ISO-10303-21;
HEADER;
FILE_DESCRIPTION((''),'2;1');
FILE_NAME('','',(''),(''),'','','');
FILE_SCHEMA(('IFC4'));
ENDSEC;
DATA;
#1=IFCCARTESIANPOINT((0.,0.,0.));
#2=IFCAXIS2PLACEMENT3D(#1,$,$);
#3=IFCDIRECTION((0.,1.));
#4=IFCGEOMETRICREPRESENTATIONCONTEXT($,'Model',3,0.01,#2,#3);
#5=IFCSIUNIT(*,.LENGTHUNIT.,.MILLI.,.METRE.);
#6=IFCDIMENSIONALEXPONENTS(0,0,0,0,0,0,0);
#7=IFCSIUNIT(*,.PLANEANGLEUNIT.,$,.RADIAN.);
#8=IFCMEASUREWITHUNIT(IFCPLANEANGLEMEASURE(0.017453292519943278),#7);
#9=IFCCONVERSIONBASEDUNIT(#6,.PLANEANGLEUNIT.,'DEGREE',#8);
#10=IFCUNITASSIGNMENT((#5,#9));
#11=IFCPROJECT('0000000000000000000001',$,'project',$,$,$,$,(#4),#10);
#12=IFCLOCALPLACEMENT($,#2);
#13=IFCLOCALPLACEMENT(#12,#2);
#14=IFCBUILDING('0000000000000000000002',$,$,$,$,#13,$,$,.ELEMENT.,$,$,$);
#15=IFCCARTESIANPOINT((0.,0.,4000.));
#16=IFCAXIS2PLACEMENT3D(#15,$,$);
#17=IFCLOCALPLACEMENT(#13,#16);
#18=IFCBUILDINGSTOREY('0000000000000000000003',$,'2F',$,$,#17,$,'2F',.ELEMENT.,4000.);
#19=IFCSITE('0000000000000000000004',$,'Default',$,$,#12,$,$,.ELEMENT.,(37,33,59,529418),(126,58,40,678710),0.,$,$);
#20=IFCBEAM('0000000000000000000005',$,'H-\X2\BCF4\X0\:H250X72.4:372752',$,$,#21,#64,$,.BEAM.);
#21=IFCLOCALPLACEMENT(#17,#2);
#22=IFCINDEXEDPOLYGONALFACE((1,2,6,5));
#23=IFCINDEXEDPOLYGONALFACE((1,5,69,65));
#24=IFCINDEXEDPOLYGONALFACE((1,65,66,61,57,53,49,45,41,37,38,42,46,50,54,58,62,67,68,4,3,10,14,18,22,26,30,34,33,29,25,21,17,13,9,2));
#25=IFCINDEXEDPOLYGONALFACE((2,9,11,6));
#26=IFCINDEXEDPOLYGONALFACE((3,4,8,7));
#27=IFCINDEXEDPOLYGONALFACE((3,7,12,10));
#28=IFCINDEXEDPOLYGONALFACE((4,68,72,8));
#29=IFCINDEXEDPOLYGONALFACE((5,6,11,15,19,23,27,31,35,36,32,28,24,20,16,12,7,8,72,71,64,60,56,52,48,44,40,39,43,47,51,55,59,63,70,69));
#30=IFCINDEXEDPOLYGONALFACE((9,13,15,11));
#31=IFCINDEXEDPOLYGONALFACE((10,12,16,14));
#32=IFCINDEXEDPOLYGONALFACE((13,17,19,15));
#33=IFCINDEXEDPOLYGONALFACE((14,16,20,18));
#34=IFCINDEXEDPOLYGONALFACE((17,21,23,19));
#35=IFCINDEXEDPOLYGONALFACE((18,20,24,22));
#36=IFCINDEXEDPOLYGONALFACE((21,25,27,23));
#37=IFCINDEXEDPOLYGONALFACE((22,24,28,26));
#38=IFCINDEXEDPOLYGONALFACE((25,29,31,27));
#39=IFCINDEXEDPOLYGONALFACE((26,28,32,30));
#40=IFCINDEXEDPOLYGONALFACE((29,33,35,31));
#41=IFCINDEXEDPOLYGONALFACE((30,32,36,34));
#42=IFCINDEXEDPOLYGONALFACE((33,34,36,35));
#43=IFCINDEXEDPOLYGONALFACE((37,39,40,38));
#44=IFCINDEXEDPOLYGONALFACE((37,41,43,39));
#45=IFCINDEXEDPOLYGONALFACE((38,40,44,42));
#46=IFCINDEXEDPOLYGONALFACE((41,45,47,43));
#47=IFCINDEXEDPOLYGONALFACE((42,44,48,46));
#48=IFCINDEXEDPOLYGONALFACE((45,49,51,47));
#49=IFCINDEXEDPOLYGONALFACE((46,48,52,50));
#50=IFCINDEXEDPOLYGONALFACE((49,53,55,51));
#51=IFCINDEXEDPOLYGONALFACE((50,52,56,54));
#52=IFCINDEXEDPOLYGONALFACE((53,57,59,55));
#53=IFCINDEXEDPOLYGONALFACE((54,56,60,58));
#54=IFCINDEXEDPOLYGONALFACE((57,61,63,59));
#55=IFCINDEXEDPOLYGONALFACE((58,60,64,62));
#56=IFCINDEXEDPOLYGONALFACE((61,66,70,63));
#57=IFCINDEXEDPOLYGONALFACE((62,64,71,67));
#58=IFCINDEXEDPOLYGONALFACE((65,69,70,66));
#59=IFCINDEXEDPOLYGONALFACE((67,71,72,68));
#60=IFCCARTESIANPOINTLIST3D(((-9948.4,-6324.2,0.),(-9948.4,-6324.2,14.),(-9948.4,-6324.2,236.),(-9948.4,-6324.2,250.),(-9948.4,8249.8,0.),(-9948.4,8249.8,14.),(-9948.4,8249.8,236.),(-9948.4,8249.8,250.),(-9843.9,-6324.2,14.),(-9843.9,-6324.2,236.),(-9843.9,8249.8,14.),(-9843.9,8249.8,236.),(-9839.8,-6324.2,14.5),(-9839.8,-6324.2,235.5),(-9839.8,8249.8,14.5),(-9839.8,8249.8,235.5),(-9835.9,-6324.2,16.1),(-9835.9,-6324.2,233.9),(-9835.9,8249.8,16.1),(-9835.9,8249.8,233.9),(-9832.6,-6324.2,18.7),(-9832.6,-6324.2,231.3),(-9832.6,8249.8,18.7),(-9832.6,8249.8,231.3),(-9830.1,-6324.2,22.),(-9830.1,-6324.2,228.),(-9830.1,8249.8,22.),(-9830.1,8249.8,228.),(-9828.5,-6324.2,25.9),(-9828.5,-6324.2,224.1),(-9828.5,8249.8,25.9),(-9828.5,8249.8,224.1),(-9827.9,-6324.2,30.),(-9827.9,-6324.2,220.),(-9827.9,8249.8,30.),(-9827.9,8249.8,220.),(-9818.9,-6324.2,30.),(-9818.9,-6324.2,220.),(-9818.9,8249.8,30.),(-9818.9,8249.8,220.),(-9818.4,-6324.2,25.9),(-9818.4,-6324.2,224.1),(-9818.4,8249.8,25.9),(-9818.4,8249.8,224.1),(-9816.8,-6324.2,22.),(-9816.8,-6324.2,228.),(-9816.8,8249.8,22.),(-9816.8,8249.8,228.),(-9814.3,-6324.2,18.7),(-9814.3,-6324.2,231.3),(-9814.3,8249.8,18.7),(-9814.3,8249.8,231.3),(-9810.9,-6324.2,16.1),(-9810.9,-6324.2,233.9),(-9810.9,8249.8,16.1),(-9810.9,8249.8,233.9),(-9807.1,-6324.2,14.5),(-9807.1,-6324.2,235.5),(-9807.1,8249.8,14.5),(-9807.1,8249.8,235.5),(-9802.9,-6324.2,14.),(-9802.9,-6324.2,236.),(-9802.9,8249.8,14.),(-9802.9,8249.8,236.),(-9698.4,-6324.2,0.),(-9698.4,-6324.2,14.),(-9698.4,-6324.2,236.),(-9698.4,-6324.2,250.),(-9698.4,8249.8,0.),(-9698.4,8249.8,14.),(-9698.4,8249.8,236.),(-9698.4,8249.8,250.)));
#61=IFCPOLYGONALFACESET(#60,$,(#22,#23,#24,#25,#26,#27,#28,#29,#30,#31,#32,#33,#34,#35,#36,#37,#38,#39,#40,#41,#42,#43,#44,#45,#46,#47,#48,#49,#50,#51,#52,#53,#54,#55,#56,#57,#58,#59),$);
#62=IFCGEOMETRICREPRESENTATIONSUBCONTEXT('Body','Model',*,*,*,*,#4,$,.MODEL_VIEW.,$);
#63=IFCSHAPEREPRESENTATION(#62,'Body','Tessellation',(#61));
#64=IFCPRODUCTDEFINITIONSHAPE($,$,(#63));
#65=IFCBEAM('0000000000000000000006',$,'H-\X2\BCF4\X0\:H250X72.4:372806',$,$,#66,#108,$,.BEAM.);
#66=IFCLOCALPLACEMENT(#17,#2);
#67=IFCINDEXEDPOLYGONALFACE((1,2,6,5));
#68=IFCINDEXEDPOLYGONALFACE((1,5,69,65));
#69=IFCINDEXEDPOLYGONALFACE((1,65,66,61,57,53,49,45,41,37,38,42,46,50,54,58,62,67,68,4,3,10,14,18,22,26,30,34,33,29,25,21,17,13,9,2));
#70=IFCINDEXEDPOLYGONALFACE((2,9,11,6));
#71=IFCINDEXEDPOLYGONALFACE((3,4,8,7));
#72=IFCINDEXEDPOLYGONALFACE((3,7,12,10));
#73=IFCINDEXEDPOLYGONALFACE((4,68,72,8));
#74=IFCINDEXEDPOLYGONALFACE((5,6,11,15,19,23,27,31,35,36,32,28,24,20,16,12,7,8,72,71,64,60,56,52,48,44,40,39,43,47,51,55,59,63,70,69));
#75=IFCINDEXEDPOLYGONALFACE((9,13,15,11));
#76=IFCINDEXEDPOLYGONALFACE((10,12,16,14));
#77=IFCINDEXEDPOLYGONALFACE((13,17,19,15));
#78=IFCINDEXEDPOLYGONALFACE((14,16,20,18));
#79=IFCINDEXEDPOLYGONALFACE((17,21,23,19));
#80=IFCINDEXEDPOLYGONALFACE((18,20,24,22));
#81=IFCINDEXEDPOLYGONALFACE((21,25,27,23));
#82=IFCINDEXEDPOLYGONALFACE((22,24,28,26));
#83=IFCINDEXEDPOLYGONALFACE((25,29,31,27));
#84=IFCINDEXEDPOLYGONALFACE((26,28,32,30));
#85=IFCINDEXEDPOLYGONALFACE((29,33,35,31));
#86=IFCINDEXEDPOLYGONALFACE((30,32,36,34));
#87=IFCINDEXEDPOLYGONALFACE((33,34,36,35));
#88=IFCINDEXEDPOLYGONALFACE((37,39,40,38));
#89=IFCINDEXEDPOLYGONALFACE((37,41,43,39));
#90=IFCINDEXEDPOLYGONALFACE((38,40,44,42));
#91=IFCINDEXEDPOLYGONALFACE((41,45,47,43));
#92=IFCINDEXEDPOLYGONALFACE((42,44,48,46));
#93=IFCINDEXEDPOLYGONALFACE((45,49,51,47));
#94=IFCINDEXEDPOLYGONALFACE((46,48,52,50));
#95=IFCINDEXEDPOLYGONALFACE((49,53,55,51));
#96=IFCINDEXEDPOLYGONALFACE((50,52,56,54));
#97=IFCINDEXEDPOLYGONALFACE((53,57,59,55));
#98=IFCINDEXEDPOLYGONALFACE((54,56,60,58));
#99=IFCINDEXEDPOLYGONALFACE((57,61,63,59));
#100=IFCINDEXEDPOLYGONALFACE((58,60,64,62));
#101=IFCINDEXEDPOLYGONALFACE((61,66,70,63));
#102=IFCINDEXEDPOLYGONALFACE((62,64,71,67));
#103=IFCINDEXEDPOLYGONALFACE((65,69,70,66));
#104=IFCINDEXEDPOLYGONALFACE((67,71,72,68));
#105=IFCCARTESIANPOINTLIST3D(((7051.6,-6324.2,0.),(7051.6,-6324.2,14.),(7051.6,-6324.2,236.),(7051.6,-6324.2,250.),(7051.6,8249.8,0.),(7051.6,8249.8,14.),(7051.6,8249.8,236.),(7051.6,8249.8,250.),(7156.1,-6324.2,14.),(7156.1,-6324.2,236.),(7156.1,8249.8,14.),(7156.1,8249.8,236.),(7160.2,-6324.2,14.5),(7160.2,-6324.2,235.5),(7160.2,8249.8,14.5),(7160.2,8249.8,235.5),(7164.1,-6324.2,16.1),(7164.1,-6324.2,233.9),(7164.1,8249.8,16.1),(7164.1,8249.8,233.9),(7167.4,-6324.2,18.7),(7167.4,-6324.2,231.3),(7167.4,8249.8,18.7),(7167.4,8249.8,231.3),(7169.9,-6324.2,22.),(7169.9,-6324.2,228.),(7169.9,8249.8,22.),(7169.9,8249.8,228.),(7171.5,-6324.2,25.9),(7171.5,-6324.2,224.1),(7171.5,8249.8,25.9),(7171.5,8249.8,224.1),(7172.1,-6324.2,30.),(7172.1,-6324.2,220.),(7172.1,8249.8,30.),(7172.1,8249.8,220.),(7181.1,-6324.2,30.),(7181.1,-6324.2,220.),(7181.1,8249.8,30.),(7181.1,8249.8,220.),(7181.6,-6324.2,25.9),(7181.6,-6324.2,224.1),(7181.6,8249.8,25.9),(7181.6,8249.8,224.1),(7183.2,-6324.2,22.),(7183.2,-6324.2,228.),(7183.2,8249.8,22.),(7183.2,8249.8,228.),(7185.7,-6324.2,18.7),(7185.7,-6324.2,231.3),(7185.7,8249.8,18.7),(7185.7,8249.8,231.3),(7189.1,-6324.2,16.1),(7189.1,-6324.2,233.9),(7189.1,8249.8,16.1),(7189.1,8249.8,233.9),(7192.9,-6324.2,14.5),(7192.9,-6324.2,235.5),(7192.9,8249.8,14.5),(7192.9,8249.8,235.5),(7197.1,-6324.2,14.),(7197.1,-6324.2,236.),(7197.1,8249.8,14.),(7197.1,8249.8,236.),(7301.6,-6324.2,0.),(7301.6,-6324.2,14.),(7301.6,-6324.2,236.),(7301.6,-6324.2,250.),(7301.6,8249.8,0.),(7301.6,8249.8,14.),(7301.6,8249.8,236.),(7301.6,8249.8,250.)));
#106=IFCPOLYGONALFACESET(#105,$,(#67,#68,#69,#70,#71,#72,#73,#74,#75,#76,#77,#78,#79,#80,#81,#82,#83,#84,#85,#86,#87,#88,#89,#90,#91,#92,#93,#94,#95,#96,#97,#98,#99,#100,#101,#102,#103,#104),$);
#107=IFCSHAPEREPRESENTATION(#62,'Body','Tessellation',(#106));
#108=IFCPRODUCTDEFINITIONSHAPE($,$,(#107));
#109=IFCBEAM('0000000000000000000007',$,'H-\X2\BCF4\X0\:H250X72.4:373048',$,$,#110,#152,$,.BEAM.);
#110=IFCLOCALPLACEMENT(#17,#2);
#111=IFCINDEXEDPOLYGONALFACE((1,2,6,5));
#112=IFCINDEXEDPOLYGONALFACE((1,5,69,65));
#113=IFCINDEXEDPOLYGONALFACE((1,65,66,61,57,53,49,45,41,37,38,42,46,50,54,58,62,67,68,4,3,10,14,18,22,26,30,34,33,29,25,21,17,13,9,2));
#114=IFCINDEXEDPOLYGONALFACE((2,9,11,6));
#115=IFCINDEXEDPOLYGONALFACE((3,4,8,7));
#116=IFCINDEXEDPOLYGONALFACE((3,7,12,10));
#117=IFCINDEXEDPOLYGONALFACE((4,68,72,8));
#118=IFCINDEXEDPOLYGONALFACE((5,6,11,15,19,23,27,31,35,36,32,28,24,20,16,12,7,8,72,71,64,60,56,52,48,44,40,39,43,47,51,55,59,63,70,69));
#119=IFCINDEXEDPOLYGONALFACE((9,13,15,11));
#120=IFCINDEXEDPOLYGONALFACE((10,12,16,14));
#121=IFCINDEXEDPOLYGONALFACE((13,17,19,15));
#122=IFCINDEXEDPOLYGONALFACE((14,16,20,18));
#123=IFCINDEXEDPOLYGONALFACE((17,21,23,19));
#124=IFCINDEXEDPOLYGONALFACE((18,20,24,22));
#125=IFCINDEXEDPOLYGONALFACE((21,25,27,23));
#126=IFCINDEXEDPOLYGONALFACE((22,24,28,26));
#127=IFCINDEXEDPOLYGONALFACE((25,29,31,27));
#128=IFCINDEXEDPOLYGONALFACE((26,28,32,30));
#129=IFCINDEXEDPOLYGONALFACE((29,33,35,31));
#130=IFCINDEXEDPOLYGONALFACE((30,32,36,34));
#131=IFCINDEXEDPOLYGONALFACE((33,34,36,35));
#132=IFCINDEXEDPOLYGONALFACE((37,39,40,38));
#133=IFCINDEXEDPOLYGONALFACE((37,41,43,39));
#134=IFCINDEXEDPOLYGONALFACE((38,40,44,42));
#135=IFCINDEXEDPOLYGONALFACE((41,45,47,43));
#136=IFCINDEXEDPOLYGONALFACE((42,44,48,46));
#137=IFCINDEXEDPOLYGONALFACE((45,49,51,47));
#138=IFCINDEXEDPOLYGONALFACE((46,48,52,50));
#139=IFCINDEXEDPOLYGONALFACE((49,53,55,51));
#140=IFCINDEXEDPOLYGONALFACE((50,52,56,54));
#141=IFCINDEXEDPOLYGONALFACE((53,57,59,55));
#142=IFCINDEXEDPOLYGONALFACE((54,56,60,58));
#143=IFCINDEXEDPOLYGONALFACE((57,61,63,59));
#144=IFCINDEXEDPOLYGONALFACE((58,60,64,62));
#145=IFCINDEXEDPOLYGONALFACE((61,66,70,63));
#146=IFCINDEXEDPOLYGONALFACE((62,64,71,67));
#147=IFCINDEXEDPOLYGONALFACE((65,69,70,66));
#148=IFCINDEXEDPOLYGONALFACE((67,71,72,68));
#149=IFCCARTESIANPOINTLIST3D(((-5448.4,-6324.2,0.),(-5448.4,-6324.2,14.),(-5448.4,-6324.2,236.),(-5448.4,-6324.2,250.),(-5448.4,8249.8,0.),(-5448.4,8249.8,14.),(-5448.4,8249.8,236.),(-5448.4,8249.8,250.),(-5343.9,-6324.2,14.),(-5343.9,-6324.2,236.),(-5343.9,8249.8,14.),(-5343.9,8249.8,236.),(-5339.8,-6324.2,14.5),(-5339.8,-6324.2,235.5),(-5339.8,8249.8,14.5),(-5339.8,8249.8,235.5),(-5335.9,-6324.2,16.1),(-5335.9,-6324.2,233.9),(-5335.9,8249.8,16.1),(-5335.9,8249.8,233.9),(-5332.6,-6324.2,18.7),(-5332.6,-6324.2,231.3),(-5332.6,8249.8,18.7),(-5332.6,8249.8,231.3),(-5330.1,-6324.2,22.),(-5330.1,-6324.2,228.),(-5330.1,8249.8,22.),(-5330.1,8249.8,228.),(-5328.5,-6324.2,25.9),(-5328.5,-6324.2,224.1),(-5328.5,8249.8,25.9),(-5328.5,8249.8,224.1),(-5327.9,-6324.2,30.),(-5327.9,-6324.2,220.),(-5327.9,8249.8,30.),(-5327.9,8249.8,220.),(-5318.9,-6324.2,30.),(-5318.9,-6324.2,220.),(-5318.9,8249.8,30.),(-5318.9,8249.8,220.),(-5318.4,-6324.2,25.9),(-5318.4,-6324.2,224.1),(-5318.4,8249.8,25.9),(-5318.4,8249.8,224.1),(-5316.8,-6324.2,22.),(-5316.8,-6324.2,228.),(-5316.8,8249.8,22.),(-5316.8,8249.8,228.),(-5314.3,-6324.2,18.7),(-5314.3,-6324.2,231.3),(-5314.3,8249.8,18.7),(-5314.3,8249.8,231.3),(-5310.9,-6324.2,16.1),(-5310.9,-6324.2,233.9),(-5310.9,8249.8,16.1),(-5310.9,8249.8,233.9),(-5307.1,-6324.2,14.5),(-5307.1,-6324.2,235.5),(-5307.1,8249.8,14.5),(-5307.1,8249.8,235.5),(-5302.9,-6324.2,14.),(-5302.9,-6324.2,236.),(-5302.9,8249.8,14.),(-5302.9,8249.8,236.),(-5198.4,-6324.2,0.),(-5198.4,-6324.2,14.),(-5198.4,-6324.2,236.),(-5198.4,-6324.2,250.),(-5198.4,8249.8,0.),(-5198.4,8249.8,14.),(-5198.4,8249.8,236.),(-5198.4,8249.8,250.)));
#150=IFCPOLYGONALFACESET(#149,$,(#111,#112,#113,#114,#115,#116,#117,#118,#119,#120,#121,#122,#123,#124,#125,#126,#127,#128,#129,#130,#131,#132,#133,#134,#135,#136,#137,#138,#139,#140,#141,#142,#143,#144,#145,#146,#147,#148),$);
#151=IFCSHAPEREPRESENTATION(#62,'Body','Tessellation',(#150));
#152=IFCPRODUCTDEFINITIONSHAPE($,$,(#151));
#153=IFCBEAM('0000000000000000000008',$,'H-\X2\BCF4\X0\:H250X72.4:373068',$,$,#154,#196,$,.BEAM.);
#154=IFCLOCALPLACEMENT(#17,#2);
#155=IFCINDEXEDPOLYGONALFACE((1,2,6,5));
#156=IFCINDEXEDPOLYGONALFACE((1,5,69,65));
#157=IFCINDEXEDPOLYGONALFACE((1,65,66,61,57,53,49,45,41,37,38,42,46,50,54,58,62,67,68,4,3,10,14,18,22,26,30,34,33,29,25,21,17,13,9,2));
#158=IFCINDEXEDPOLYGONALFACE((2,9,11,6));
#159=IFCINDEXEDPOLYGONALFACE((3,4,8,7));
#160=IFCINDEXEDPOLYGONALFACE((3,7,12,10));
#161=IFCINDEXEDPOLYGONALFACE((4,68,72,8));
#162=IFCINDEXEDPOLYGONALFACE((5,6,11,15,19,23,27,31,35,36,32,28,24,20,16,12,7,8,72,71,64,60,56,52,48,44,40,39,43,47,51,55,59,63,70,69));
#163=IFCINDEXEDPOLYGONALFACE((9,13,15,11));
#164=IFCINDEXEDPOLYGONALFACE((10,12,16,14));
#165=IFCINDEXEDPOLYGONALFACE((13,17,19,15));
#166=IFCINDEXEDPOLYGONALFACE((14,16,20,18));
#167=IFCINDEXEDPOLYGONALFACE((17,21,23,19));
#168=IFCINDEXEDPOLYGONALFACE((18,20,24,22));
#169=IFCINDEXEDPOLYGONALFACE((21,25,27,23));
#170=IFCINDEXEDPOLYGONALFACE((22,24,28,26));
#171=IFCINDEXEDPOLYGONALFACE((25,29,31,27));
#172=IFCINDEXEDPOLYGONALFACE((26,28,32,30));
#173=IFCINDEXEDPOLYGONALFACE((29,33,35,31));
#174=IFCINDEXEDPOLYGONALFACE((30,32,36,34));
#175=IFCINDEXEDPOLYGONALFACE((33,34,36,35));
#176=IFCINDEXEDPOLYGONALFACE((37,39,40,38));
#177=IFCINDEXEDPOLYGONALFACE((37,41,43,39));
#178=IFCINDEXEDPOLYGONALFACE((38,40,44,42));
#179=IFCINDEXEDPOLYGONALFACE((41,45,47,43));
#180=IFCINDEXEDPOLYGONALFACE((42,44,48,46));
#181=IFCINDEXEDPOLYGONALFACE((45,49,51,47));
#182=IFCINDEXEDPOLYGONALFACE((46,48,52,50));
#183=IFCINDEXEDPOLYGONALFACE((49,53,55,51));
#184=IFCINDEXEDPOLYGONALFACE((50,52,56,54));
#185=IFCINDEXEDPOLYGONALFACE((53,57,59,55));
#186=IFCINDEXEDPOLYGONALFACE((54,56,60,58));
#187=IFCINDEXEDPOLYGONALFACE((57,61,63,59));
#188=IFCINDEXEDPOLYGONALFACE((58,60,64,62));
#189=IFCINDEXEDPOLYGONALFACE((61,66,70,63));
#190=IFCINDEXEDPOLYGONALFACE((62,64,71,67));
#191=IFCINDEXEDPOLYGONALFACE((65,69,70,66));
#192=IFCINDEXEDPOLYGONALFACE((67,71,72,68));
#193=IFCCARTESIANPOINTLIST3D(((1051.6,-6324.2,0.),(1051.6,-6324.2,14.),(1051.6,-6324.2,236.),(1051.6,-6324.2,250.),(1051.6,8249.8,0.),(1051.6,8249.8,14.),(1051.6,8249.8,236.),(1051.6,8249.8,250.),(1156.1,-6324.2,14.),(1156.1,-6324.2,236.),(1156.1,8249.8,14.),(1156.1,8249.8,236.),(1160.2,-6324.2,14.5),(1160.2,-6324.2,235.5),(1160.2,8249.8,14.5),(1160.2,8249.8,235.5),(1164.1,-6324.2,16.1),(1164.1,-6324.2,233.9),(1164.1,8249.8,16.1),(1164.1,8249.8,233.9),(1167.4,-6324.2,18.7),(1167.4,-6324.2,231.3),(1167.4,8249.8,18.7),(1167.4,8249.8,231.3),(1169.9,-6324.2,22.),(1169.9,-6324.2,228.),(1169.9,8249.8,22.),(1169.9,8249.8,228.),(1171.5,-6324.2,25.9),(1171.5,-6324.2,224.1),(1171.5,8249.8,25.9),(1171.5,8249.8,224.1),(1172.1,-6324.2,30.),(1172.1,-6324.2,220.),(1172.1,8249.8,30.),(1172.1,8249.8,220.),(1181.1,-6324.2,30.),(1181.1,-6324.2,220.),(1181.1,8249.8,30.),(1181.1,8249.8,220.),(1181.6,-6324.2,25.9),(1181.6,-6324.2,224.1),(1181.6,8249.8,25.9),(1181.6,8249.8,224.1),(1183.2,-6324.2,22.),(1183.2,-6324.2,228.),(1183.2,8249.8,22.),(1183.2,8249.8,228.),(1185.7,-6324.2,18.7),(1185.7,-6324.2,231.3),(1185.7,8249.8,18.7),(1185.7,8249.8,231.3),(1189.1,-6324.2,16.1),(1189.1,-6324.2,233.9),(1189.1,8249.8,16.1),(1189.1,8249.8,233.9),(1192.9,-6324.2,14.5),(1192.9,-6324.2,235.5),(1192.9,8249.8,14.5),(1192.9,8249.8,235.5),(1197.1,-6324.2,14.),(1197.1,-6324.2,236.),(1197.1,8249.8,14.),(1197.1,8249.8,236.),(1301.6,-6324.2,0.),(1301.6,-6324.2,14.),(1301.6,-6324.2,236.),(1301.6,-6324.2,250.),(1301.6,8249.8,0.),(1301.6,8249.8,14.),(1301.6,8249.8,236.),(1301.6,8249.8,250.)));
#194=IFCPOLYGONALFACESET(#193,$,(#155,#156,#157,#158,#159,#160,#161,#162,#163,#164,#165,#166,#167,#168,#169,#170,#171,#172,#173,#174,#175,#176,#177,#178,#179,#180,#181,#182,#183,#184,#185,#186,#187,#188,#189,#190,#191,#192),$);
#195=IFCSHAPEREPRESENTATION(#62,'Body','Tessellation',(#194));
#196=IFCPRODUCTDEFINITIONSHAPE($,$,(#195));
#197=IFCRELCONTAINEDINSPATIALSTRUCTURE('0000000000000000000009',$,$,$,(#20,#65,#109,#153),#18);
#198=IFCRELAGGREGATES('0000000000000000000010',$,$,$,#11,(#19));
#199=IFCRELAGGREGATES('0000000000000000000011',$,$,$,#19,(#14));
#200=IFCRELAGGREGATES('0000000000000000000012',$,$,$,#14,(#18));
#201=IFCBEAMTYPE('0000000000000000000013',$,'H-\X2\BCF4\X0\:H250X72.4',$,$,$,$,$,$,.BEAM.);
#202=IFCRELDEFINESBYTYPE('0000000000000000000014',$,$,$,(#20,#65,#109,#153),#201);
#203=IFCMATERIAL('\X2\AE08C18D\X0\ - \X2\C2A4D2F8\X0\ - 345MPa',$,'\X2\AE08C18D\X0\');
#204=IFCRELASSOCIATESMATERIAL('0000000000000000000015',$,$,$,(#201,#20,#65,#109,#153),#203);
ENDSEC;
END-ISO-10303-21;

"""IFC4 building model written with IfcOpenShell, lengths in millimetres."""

from ifc_helpers import new_model, entity, si_unit, converted_unit, direction, frame, origin, place, context, subcontext, project, spatial, line, arc, indexed_curve, outline, extrude, source, transform, mapped, material, type_object, type_shapes, element, save


model = new_model("IFC4")

# Units and contexts
model_context = context("Model", 3, precision=0.01, world=origin(), true_north=direction((0.0, 1.0)))
body_context = subcontext(model_context, "Body", "Model", "MODEL_VIEW")
ifc_project = project(units=[si_unit("LENGTHUNIT", "METRE", prefix="MILLI"), converted_unit("PLANEANGLEUNIT", "DEGREE", entity("IfcPlaneAngleMeasure", 0.017453292519943278), si_unit("PLANEANGLEUNIT", "RADIAN"), dimensions=[0, 0, 0, 0, 0, 0, 0])], contexts=[model_context])

# Site, building, storey
site_placement = place(None, origin())
site = spatial("IfcSite", under=ifc_project, at=site_placement, Name="Default", CompositionType="ELEMENT", RefLatitude=(37, 33, 59, 529418), RefLongitude=(126, 58, 40, 678710), RefElevation=0.0)
building_placement = place(site_placement, origin())
building = spatial("IfcBuilding", under=site, at=building_placement, CompositionType="ELEMENT")
storey_placement = place(building_placement, frame((0.0, 0.0, 4000.0)))
storey = spatial("IfcBuildingStorey", under=building, at=storey_placement, Name="2F", LongName="2F", CompositionType="ELEMENT", Elevation=4000.0)

# Shared definitions
ifc_material = material(Name="금속 - 스틸 - 345MPa", Category="금속")

# Beams
beam_type_1 = type_object("IfcBeamType", Name="H-보:H250X72.4", PredefinedType="BEAM", material=ifc_material)
shared_shape_1 = source(origin(), body_context, "Body", "SweptSolid", [
    extrude(outline(indexed_curve([(-125.0, -111.0), (-125.0, -125.0), (125.0, -125.0), (125.0, -111.0), (20.5, -111.0), (9.2, -106.3), (4.5, -95.0), (4.5, 95.0), (9.2, 106.3), (20.5, 111.0), (125.0, 111.0), (125.0, 125.0), (-125.0, 125.0), (-125.0, 111.0), (-20.5, 111.0), (-9.2, 106.3), (-4.5, 95.0), (-4.5, -95.0), (-9.2, -106.3), (-20.5, -111.0)], segments=[line(1, 2, 3, 4, 5), arc(5, 6, 7), line(7, 8), arc(8, 9, 10), line(10, 11, 12, 13, 14, 15), arc(15, 16, 17), line(17, 18), arc(18, 19, 20), line(20, 1)], self_intersect=False)), frame((-7287.0, 0.0, 0.0), z_axis=(-1.0, 0.0, 0.0), x_axis=(0.0, -1.0, 0.0)), (0.0, 0.0, -1.0), 14574.0),
])
type_shapes(beam_type_1, [shared_shape_1])
for number, where, z_axis, x_axis, name in (
    (1, (-9823.4, 962.8, 125.0), (0.0, 0.0, 1.0), (0.0, -1.0, 0.0), "H-보:H250X72.4:372752"),
    (2, (7176.6, 962.8, 125.0), (0.0, 0.0, 1.0), (0.0, 1.0, 0.0), "H-보:H250X72.4:372806"),
    (3, (-5323.4, 962.8, 125.0), (0.0, 0.0, 1.0), (0.0, 1.0, 0.0), "H-보:H250X72.4:373048"),
    (4, (1176.6, 962.8, 125.0), (0.0, 0.0, 1.0), (0.0, -1.0, 0.0), "H-보:H250X72.4:373068"),
):
    element("IfcBeam", number, at=place(storey_placement, frame(where, z_axis=z_axis, x_axis=x_axis)), inside=storey, type_object=beam_type_1, material=ifc_material, Name=name, PredefinedType="BEAM", context=body_context, shape_type="MappedRepresentation", body=[
        mapped(shared_shape_1, transform((0.0, 0.0, 0.0), scale=1.0)),
    ])

save(model, "model.ifc")
